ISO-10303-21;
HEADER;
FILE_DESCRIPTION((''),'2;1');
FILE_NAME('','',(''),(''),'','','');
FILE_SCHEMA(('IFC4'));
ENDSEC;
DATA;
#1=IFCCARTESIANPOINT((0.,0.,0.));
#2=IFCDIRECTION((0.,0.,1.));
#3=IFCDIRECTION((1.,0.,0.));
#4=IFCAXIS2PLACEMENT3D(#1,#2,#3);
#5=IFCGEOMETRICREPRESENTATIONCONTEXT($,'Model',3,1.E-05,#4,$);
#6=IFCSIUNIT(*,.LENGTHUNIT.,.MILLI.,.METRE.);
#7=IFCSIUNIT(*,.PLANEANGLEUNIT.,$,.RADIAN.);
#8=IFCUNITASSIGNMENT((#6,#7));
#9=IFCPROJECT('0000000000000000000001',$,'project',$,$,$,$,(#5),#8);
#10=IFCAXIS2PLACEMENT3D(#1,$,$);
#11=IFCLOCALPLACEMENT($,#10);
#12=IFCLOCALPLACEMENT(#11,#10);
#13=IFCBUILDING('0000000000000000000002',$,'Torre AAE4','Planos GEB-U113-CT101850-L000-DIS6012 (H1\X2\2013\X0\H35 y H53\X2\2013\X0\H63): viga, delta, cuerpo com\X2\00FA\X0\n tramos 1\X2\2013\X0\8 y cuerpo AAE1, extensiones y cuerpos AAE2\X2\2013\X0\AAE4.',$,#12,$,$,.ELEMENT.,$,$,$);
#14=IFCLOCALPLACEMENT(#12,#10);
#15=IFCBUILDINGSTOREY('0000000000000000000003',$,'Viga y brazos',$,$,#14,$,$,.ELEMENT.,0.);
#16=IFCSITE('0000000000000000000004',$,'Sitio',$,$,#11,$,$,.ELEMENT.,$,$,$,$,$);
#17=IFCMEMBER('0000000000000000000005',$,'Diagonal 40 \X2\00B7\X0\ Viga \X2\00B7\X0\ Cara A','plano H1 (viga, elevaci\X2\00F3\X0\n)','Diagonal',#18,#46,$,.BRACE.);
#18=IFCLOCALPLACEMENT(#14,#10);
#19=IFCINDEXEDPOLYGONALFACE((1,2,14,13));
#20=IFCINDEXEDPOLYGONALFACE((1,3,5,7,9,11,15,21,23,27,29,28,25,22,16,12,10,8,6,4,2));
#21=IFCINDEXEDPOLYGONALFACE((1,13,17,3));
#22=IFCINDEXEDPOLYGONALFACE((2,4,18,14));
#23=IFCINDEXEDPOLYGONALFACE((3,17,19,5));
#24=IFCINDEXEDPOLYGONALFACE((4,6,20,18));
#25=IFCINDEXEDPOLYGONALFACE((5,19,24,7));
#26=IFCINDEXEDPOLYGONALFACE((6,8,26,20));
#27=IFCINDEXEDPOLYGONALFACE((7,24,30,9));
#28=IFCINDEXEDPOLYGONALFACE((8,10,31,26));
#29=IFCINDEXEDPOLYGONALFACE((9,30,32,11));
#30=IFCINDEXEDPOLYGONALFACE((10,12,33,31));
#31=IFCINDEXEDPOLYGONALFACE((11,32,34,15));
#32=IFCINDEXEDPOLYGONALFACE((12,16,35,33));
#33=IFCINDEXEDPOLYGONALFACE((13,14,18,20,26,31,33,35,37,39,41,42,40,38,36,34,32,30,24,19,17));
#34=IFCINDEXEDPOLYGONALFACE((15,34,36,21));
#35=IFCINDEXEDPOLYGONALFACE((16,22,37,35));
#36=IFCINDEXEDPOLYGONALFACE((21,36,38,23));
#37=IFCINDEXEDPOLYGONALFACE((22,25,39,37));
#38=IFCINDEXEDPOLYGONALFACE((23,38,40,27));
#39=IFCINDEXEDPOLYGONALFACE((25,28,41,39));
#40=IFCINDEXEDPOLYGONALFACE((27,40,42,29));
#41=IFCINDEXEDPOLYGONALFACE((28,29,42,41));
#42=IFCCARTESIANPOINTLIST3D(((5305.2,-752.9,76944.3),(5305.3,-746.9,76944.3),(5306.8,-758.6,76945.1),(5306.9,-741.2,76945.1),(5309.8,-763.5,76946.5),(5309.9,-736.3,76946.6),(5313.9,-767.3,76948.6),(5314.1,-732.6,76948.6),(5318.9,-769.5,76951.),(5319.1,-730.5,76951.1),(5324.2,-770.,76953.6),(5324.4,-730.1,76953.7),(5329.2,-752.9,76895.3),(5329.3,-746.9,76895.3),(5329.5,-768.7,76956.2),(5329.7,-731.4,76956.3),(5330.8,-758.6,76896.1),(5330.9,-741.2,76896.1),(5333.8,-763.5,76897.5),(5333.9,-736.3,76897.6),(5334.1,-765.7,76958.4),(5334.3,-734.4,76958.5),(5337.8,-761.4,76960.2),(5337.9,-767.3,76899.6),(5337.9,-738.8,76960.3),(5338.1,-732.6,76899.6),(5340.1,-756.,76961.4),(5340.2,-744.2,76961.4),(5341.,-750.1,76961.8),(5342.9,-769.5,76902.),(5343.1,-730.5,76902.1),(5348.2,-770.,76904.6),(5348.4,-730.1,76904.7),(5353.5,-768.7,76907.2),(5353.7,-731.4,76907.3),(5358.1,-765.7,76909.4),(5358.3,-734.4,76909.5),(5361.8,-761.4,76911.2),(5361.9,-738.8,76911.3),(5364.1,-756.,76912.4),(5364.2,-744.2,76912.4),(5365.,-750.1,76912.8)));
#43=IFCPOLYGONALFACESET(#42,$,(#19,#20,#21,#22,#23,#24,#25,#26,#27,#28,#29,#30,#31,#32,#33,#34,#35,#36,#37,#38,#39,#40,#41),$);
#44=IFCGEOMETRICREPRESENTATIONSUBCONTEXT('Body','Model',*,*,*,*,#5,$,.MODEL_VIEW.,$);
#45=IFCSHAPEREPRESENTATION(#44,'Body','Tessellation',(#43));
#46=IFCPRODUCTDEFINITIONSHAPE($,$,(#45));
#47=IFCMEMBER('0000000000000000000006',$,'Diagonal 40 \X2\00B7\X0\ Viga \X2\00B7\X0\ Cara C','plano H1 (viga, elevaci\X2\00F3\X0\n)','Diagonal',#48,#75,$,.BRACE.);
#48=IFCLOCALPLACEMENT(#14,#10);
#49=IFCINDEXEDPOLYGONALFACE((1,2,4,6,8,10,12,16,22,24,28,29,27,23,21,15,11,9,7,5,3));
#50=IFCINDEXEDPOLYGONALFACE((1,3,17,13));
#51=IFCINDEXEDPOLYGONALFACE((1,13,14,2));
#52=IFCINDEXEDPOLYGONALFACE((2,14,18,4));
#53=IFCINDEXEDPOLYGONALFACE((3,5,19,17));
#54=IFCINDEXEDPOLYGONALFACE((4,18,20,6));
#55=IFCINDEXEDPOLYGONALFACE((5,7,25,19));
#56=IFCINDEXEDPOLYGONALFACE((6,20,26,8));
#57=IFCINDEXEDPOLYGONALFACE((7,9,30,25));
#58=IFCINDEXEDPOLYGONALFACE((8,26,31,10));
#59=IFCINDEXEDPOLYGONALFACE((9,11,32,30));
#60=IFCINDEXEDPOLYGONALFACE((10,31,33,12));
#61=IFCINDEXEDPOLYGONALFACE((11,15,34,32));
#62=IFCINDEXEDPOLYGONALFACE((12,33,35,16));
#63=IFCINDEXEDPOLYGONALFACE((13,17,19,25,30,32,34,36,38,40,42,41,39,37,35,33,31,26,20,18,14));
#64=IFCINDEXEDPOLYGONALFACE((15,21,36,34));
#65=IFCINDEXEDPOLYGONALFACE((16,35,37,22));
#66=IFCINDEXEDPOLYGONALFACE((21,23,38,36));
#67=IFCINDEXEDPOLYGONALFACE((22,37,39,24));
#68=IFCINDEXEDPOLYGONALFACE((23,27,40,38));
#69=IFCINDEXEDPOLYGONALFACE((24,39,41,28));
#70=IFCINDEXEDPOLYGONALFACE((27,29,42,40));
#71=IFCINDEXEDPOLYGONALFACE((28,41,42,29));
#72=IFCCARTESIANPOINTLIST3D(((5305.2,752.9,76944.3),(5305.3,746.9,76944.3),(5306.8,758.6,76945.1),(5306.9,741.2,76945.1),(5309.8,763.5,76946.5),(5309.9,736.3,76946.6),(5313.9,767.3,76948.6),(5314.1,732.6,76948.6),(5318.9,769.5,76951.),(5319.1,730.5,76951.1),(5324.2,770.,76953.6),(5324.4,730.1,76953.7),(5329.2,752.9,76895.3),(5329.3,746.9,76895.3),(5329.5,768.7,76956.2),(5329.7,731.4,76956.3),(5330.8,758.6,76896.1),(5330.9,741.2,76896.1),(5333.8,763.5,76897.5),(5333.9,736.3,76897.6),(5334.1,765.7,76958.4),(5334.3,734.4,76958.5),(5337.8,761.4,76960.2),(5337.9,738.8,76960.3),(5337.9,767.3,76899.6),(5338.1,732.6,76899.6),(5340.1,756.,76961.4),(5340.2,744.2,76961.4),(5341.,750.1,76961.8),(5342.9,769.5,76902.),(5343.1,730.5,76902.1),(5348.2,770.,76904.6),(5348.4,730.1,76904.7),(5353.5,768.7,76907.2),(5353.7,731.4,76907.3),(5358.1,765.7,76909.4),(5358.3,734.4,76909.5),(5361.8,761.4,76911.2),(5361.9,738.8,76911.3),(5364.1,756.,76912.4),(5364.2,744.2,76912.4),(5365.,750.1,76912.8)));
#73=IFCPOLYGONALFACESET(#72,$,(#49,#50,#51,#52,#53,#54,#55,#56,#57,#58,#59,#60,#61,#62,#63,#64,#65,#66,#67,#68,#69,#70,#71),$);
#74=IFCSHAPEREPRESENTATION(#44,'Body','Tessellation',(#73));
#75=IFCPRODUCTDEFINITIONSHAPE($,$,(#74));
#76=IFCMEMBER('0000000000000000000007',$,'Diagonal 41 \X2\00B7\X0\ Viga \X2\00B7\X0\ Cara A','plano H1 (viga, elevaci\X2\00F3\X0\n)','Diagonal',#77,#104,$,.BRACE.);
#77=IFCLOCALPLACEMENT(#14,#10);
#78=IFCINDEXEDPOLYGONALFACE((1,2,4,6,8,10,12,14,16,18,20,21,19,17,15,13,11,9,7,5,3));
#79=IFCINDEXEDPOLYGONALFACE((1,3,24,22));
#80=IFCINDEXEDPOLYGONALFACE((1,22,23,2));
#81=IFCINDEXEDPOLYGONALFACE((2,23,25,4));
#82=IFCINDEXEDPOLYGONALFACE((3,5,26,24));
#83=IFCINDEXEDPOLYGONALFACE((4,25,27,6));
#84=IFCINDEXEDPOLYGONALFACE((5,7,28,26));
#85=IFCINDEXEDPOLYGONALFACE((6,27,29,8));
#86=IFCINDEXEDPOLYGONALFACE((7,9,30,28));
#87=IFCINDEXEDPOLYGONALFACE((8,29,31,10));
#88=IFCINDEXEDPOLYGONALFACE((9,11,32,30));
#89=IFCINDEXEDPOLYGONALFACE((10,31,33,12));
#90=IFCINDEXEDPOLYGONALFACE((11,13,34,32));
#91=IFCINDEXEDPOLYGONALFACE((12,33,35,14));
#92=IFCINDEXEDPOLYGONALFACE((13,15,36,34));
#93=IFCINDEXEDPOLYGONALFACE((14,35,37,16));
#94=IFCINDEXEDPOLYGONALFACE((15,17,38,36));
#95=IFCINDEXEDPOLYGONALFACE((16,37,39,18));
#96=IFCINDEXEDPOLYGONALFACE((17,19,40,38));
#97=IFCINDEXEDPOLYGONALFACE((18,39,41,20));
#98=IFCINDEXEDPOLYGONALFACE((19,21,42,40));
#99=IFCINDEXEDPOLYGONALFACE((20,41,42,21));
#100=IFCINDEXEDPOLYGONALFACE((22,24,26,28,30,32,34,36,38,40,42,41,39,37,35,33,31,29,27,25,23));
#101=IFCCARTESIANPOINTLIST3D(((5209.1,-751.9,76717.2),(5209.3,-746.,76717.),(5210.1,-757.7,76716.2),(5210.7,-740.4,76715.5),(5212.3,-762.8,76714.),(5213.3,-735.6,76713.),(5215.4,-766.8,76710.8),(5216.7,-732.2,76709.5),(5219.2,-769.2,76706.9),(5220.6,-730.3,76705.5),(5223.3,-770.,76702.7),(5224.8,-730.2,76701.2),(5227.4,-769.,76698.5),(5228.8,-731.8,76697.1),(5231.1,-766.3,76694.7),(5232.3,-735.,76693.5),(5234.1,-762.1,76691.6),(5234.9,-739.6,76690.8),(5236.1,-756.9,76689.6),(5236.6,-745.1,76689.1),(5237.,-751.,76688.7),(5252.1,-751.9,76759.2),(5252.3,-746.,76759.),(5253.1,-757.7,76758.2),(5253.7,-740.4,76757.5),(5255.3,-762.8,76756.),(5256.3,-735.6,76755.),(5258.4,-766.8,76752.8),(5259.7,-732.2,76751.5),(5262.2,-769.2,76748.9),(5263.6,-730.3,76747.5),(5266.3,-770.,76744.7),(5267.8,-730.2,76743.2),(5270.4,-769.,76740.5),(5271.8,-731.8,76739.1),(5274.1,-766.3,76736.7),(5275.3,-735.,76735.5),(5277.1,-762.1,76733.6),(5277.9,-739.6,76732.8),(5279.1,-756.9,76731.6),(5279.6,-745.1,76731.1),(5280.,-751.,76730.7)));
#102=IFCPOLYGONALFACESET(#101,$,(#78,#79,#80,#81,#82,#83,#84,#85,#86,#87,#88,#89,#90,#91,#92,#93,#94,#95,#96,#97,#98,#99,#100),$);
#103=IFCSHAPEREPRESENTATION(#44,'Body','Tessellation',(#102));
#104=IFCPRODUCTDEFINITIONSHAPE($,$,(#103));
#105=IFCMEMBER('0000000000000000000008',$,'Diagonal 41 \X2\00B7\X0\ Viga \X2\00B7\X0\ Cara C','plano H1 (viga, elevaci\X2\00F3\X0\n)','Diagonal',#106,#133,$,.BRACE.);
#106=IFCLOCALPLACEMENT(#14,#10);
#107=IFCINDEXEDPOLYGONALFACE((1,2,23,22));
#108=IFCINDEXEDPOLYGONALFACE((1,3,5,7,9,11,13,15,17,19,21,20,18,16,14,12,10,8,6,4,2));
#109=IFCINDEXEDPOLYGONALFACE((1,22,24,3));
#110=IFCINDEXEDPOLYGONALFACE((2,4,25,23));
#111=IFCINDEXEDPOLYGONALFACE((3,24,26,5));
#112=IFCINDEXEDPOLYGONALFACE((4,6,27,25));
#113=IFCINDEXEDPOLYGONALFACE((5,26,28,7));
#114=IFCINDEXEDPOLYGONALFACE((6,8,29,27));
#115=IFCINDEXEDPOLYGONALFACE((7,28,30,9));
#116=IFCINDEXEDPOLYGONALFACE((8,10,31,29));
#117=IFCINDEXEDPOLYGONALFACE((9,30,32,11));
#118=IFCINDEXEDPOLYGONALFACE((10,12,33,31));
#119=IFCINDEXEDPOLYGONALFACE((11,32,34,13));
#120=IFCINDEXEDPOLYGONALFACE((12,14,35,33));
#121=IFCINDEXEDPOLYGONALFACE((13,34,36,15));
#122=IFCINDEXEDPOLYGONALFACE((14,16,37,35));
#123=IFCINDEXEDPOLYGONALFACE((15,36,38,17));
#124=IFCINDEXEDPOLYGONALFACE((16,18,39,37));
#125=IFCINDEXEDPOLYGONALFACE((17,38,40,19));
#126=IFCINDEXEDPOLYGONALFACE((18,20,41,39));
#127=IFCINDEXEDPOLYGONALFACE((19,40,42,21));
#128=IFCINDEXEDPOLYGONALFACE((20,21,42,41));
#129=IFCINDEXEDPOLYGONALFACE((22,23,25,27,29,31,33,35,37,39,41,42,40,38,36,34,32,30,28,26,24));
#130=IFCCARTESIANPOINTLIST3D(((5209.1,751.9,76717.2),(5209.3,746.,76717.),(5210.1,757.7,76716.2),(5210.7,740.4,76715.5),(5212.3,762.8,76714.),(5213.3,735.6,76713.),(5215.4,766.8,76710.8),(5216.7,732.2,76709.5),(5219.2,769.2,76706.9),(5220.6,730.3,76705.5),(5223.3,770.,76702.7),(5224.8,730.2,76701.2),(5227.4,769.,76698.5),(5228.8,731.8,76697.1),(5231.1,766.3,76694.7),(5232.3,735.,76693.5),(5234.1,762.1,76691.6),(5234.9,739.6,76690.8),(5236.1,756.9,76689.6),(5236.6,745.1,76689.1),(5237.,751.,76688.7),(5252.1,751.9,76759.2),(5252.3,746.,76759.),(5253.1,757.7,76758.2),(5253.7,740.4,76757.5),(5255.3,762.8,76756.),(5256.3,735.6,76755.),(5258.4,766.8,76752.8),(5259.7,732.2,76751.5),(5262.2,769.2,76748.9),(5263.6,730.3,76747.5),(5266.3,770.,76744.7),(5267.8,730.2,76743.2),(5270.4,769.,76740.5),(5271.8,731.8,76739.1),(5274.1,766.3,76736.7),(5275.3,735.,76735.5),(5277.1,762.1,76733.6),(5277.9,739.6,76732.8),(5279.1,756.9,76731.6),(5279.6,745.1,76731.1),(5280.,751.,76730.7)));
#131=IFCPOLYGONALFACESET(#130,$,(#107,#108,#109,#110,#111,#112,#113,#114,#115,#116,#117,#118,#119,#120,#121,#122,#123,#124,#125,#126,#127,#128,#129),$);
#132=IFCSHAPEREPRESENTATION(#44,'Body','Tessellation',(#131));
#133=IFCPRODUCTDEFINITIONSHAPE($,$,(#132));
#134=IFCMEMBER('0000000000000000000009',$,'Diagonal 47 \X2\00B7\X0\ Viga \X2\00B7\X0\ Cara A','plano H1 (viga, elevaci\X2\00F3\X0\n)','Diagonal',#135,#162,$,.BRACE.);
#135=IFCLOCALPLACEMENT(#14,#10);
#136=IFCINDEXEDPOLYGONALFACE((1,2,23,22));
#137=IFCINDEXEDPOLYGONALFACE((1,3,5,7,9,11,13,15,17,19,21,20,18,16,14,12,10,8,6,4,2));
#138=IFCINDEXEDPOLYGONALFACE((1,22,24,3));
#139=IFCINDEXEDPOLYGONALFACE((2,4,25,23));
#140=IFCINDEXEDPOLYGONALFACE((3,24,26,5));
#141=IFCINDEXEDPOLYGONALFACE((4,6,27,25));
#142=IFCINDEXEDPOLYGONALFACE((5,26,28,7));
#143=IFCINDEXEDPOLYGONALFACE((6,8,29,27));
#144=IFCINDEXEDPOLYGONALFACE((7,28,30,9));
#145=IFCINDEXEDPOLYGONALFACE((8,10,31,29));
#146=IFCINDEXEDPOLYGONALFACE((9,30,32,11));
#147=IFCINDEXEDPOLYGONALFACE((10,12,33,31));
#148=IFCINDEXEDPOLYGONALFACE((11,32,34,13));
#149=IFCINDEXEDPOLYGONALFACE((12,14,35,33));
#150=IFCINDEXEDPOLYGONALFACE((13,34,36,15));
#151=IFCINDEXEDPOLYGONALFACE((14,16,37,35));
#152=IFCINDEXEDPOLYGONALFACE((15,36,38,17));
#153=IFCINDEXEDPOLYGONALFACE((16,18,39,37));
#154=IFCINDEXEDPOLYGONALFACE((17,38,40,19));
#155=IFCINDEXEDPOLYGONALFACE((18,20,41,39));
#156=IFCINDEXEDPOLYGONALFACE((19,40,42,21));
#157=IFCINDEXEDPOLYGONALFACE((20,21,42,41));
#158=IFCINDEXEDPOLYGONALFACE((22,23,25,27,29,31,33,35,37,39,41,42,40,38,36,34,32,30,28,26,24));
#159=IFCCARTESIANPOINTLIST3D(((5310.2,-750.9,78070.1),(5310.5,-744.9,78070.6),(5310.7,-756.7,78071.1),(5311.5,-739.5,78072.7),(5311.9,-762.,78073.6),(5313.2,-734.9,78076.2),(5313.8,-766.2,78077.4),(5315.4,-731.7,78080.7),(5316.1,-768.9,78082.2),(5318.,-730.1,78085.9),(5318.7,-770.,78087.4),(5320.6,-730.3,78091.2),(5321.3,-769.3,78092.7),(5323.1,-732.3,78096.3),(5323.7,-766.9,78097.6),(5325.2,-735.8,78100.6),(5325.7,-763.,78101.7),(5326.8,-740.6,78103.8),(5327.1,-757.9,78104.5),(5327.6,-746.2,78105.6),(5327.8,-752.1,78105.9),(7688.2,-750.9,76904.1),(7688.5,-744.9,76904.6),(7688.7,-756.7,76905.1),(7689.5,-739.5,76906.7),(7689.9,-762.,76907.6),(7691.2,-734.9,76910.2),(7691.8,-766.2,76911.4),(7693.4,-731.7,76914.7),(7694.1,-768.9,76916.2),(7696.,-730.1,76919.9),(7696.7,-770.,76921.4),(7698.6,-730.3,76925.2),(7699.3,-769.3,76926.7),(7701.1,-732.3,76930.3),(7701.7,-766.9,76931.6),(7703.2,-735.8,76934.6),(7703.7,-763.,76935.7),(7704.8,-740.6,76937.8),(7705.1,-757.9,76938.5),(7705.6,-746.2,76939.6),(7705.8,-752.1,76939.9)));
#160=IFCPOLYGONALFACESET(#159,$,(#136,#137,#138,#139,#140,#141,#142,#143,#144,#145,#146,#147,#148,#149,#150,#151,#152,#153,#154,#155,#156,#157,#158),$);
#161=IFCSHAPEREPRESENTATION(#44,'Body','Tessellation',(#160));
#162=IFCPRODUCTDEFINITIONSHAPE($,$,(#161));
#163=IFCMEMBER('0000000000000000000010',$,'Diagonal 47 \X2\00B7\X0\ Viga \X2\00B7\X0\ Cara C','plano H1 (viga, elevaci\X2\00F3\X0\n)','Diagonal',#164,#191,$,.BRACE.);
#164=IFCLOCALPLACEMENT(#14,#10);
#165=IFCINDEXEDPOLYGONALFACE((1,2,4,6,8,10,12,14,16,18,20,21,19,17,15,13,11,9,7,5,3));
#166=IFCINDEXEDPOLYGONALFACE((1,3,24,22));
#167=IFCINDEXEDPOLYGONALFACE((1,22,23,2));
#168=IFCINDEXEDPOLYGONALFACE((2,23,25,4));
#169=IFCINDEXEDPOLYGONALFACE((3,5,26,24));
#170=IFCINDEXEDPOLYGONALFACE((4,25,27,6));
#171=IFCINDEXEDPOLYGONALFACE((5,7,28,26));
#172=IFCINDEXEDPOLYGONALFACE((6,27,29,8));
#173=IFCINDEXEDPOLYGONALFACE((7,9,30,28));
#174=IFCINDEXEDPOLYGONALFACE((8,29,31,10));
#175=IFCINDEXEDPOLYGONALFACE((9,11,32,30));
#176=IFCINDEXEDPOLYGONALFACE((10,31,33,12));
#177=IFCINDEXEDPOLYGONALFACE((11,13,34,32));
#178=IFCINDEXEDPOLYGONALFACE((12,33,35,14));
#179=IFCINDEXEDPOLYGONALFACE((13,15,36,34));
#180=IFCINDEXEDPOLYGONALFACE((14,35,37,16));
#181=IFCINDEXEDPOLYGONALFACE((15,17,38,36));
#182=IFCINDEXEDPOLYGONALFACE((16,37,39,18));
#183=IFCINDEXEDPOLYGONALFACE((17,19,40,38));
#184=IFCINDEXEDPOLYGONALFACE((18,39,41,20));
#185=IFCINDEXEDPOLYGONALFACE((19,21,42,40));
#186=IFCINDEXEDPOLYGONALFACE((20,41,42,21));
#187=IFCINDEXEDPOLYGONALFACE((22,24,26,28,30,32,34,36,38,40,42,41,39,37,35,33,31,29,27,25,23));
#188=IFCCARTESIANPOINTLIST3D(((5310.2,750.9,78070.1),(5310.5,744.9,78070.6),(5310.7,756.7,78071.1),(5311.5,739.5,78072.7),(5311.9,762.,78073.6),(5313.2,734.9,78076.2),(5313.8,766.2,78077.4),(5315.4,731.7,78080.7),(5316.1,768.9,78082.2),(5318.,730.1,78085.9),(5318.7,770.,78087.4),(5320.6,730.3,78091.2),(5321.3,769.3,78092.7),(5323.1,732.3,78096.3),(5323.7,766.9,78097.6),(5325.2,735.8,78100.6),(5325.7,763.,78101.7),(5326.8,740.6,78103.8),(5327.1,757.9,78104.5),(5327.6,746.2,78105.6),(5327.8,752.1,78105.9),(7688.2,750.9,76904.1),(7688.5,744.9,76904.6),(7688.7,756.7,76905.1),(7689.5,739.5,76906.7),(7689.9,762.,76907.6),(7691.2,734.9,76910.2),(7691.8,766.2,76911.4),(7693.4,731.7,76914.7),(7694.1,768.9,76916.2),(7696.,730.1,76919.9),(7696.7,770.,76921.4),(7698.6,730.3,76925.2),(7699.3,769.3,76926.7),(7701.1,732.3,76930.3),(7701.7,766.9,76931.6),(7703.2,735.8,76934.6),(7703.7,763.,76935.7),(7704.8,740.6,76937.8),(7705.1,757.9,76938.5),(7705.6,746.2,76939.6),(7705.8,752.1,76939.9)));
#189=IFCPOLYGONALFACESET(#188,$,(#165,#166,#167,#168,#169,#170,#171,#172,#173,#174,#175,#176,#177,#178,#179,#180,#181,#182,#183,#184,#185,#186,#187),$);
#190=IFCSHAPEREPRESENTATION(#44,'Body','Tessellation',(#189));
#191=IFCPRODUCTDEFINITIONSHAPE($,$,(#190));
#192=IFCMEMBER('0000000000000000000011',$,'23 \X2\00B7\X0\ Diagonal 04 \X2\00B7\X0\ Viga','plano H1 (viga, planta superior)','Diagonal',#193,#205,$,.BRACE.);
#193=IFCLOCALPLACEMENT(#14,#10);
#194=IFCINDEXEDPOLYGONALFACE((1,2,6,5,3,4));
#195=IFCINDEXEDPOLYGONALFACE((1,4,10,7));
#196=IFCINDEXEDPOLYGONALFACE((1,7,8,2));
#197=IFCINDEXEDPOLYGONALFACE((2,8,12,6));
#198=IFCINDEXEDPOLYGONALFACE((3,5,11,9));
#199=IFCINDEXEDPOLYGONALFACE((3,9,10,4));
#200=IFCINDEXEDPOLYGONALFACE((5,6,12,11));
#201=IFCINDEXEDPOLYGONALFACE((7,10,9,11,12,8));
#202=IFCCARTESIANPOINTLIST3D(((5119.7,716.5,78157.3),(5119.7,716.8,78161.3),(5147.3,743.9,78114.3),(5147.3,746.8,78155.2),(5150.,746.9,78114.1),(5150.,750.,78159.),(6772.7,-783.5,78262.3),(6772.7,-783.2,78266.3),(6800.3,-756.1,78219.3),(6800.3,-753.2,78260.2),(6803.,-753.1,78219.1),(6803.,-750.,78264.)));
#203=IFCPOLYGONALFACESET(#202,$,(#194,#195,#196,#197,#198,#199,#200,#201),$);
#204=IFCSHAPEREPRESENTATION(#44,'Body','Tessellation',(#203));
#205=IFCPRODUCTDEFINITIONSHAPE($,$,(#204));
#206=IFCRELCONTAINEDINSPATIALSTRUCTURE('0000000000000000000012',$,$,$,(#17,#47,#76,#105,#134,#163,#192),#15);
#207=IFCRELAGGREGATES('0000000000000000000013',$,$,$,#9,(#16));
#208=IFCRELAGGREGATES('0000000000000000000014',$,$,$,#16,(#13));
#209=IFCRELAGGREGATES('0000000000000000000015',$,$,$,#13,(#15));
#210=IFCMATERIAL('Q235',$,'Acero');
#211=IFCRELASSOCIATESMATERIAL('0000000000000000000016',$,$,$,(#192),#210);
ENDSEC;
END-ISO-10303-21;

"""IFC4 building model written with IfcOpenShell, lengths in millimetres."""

from ifc_helpers import new_model, si_unit, frame, frame_2d, origin, origin_with_axes, place, context, subcontext, project, spatial, circle, l_section, extrude, material, element, save


model = new_model("IFC4")

# Units and contexts
model_context = context("Model", 3, precision=1e-05, world=origin_with_axes())
body_context = subcontext(model_context, "Body", "Model", "MODEL_VIEW")
ifc_project = project(units=[si_unit("LENGTHUNIT", "METRE", prefix="MILLI"), si_unit("PLANEANGLEUNIT", "RADIAN")], contexts=[model_context])

# Site, building, storey
site_placement = place(None, origin())
site = spatial("IfcSite", under=ifc_project, at=site_placement, Name="Sitio", CompositionType="ELEMENT")
building_placement = place(site_placement, origin())
building = spatial("IfcBuilding", under=site, at=building_placement, Name="Torre AAE4", Description="Planos GEB-U113-CT101850-L000-DIS6012 (H1–H35 y H53–H63): viga, delta, cuerpo común tramos 1–8 y cuerpo AAE1, extensiones y cuerpos AAE2–AAE4.", CompositionType="ELEMENT")
storey_placement = place(building_placement, origin())
storey = spatial("IfcBuildingStorey", under=building, at=storey_placement, Name="Viga y brazos", CompositionType="ELEMENT", Elevation=0.0)

# Members
ifc_material = material(Name="Q235", Category="Acero")
for number, where, z_axis, x_axis, name in (
    (1, (5347.0, -750.0, 76904.0), (-0.439867, 0.0, 0.898063), (-0.887258, 0.154655, -0.434575), "Diagonal 40 · Viga · Cara A"),
    (2, (5347.0, 750.0, 76904.0), (-0.439867, 0.0, 0.898063), (-0.887258, -0.154655, -0.434575), "Diagonal 40 · Viga · Cara C"),
):
    element("IfcMember", number, at=place(storey_placement, frame(where, z_axis=z_axis, x_axis=x_axis)), inside=storey, Name=name, Description="plano H1 (viga, elevación)", ObjectType="Diagonal", PredefinedType="BRACE", context=body_context, shape_type="SweptSolid", body=[
        extrude(circle(Radius=20.0), None, (0.0, 0.0, 1.0), 54.6),
    ])
for number, where, z_axis, x_axis, name in (
    (3, (5266.0, -750.0, 76745.0), (-0.715376, 0.0, -0.69874), (-0.68455, 0.200508, 0.700848), "Diagonal 41 · Viga · Cara A"),
    (4, (5266.0, 750.0, 76745.0), (-0.715376, 0.0, -0.69874), (-0.68455, -0.200508, 0.700848), "Diagonal 41 · Viga · Cara C"),
):
    element("IfcMember", number, at=place(storey_placement, frame(where, z_axis=z_axis, x_axis=x_axis)), inside=storey, Name=name, Description="plano H1 (viga, elevación)", ObjectType="Diagonal", PredefinedType="BRACE", context=body_context, shape_type="SweptSolid", body=[
        extrude(circle(Radius=20.0), None, (0.0, 0.0, 1.0), 60.1),
    ])
for number, where, z_axis, x_axis, name in (
    (5, (5319.0, -750.0, 78088.0), (0.897874, 0.0, -0.440253), (-0.425903, 0.253233, -0.868608), "Diagonal 47 · Viga · Cara A"),
    (6, (5319.0, 750.0, 78088.0), (0.897874, 0.0, -0.440253), (-0.425903, -0.253233, -0.868608), "Diagonal 47 · Viga · Cara C"),
):
    element("IfcMember", number, at=place(storey_placement, frame(where, z_axis=z_axis, x_axis=x_axis)), inside=storey, Name=name, Description="plano H1 (viga, elevación)", ObjectType="Diagonal", PredefinedType="BRACE", context=body_context, shape_type="SweptSolid", body=[
        extrude(circle(Radius=20.0), None, (0.0, 0.0, 1.0), 2648.5),
    ])
member_1_placement = place(storey_placement, frame((5150.0, 750.0, 78159.0), z_axis=(0.73973, -0.671261, 0.046988), x_axis=(-0.672904, -0.737924, 0.051655)))
element("IfcMember", 7, at=member_1_placement, inside=storey, material=ifc_material, Name="23 · Diagonal 04 · Viga", Description="plano H1 (viga, planta superior)", ObjectType="Diagonal", PredefinedType="BRACE", context=body_context, shape_type="SweptSolid", body=[
    extrude(l_section(Depth=45.0, Width=45.0, Thickness=4.0, at=frame_2d((22.5, 22.5))), None, (0.0, 0.0, 1.0), 2234.6),
])

save(model, "model.ifc")
